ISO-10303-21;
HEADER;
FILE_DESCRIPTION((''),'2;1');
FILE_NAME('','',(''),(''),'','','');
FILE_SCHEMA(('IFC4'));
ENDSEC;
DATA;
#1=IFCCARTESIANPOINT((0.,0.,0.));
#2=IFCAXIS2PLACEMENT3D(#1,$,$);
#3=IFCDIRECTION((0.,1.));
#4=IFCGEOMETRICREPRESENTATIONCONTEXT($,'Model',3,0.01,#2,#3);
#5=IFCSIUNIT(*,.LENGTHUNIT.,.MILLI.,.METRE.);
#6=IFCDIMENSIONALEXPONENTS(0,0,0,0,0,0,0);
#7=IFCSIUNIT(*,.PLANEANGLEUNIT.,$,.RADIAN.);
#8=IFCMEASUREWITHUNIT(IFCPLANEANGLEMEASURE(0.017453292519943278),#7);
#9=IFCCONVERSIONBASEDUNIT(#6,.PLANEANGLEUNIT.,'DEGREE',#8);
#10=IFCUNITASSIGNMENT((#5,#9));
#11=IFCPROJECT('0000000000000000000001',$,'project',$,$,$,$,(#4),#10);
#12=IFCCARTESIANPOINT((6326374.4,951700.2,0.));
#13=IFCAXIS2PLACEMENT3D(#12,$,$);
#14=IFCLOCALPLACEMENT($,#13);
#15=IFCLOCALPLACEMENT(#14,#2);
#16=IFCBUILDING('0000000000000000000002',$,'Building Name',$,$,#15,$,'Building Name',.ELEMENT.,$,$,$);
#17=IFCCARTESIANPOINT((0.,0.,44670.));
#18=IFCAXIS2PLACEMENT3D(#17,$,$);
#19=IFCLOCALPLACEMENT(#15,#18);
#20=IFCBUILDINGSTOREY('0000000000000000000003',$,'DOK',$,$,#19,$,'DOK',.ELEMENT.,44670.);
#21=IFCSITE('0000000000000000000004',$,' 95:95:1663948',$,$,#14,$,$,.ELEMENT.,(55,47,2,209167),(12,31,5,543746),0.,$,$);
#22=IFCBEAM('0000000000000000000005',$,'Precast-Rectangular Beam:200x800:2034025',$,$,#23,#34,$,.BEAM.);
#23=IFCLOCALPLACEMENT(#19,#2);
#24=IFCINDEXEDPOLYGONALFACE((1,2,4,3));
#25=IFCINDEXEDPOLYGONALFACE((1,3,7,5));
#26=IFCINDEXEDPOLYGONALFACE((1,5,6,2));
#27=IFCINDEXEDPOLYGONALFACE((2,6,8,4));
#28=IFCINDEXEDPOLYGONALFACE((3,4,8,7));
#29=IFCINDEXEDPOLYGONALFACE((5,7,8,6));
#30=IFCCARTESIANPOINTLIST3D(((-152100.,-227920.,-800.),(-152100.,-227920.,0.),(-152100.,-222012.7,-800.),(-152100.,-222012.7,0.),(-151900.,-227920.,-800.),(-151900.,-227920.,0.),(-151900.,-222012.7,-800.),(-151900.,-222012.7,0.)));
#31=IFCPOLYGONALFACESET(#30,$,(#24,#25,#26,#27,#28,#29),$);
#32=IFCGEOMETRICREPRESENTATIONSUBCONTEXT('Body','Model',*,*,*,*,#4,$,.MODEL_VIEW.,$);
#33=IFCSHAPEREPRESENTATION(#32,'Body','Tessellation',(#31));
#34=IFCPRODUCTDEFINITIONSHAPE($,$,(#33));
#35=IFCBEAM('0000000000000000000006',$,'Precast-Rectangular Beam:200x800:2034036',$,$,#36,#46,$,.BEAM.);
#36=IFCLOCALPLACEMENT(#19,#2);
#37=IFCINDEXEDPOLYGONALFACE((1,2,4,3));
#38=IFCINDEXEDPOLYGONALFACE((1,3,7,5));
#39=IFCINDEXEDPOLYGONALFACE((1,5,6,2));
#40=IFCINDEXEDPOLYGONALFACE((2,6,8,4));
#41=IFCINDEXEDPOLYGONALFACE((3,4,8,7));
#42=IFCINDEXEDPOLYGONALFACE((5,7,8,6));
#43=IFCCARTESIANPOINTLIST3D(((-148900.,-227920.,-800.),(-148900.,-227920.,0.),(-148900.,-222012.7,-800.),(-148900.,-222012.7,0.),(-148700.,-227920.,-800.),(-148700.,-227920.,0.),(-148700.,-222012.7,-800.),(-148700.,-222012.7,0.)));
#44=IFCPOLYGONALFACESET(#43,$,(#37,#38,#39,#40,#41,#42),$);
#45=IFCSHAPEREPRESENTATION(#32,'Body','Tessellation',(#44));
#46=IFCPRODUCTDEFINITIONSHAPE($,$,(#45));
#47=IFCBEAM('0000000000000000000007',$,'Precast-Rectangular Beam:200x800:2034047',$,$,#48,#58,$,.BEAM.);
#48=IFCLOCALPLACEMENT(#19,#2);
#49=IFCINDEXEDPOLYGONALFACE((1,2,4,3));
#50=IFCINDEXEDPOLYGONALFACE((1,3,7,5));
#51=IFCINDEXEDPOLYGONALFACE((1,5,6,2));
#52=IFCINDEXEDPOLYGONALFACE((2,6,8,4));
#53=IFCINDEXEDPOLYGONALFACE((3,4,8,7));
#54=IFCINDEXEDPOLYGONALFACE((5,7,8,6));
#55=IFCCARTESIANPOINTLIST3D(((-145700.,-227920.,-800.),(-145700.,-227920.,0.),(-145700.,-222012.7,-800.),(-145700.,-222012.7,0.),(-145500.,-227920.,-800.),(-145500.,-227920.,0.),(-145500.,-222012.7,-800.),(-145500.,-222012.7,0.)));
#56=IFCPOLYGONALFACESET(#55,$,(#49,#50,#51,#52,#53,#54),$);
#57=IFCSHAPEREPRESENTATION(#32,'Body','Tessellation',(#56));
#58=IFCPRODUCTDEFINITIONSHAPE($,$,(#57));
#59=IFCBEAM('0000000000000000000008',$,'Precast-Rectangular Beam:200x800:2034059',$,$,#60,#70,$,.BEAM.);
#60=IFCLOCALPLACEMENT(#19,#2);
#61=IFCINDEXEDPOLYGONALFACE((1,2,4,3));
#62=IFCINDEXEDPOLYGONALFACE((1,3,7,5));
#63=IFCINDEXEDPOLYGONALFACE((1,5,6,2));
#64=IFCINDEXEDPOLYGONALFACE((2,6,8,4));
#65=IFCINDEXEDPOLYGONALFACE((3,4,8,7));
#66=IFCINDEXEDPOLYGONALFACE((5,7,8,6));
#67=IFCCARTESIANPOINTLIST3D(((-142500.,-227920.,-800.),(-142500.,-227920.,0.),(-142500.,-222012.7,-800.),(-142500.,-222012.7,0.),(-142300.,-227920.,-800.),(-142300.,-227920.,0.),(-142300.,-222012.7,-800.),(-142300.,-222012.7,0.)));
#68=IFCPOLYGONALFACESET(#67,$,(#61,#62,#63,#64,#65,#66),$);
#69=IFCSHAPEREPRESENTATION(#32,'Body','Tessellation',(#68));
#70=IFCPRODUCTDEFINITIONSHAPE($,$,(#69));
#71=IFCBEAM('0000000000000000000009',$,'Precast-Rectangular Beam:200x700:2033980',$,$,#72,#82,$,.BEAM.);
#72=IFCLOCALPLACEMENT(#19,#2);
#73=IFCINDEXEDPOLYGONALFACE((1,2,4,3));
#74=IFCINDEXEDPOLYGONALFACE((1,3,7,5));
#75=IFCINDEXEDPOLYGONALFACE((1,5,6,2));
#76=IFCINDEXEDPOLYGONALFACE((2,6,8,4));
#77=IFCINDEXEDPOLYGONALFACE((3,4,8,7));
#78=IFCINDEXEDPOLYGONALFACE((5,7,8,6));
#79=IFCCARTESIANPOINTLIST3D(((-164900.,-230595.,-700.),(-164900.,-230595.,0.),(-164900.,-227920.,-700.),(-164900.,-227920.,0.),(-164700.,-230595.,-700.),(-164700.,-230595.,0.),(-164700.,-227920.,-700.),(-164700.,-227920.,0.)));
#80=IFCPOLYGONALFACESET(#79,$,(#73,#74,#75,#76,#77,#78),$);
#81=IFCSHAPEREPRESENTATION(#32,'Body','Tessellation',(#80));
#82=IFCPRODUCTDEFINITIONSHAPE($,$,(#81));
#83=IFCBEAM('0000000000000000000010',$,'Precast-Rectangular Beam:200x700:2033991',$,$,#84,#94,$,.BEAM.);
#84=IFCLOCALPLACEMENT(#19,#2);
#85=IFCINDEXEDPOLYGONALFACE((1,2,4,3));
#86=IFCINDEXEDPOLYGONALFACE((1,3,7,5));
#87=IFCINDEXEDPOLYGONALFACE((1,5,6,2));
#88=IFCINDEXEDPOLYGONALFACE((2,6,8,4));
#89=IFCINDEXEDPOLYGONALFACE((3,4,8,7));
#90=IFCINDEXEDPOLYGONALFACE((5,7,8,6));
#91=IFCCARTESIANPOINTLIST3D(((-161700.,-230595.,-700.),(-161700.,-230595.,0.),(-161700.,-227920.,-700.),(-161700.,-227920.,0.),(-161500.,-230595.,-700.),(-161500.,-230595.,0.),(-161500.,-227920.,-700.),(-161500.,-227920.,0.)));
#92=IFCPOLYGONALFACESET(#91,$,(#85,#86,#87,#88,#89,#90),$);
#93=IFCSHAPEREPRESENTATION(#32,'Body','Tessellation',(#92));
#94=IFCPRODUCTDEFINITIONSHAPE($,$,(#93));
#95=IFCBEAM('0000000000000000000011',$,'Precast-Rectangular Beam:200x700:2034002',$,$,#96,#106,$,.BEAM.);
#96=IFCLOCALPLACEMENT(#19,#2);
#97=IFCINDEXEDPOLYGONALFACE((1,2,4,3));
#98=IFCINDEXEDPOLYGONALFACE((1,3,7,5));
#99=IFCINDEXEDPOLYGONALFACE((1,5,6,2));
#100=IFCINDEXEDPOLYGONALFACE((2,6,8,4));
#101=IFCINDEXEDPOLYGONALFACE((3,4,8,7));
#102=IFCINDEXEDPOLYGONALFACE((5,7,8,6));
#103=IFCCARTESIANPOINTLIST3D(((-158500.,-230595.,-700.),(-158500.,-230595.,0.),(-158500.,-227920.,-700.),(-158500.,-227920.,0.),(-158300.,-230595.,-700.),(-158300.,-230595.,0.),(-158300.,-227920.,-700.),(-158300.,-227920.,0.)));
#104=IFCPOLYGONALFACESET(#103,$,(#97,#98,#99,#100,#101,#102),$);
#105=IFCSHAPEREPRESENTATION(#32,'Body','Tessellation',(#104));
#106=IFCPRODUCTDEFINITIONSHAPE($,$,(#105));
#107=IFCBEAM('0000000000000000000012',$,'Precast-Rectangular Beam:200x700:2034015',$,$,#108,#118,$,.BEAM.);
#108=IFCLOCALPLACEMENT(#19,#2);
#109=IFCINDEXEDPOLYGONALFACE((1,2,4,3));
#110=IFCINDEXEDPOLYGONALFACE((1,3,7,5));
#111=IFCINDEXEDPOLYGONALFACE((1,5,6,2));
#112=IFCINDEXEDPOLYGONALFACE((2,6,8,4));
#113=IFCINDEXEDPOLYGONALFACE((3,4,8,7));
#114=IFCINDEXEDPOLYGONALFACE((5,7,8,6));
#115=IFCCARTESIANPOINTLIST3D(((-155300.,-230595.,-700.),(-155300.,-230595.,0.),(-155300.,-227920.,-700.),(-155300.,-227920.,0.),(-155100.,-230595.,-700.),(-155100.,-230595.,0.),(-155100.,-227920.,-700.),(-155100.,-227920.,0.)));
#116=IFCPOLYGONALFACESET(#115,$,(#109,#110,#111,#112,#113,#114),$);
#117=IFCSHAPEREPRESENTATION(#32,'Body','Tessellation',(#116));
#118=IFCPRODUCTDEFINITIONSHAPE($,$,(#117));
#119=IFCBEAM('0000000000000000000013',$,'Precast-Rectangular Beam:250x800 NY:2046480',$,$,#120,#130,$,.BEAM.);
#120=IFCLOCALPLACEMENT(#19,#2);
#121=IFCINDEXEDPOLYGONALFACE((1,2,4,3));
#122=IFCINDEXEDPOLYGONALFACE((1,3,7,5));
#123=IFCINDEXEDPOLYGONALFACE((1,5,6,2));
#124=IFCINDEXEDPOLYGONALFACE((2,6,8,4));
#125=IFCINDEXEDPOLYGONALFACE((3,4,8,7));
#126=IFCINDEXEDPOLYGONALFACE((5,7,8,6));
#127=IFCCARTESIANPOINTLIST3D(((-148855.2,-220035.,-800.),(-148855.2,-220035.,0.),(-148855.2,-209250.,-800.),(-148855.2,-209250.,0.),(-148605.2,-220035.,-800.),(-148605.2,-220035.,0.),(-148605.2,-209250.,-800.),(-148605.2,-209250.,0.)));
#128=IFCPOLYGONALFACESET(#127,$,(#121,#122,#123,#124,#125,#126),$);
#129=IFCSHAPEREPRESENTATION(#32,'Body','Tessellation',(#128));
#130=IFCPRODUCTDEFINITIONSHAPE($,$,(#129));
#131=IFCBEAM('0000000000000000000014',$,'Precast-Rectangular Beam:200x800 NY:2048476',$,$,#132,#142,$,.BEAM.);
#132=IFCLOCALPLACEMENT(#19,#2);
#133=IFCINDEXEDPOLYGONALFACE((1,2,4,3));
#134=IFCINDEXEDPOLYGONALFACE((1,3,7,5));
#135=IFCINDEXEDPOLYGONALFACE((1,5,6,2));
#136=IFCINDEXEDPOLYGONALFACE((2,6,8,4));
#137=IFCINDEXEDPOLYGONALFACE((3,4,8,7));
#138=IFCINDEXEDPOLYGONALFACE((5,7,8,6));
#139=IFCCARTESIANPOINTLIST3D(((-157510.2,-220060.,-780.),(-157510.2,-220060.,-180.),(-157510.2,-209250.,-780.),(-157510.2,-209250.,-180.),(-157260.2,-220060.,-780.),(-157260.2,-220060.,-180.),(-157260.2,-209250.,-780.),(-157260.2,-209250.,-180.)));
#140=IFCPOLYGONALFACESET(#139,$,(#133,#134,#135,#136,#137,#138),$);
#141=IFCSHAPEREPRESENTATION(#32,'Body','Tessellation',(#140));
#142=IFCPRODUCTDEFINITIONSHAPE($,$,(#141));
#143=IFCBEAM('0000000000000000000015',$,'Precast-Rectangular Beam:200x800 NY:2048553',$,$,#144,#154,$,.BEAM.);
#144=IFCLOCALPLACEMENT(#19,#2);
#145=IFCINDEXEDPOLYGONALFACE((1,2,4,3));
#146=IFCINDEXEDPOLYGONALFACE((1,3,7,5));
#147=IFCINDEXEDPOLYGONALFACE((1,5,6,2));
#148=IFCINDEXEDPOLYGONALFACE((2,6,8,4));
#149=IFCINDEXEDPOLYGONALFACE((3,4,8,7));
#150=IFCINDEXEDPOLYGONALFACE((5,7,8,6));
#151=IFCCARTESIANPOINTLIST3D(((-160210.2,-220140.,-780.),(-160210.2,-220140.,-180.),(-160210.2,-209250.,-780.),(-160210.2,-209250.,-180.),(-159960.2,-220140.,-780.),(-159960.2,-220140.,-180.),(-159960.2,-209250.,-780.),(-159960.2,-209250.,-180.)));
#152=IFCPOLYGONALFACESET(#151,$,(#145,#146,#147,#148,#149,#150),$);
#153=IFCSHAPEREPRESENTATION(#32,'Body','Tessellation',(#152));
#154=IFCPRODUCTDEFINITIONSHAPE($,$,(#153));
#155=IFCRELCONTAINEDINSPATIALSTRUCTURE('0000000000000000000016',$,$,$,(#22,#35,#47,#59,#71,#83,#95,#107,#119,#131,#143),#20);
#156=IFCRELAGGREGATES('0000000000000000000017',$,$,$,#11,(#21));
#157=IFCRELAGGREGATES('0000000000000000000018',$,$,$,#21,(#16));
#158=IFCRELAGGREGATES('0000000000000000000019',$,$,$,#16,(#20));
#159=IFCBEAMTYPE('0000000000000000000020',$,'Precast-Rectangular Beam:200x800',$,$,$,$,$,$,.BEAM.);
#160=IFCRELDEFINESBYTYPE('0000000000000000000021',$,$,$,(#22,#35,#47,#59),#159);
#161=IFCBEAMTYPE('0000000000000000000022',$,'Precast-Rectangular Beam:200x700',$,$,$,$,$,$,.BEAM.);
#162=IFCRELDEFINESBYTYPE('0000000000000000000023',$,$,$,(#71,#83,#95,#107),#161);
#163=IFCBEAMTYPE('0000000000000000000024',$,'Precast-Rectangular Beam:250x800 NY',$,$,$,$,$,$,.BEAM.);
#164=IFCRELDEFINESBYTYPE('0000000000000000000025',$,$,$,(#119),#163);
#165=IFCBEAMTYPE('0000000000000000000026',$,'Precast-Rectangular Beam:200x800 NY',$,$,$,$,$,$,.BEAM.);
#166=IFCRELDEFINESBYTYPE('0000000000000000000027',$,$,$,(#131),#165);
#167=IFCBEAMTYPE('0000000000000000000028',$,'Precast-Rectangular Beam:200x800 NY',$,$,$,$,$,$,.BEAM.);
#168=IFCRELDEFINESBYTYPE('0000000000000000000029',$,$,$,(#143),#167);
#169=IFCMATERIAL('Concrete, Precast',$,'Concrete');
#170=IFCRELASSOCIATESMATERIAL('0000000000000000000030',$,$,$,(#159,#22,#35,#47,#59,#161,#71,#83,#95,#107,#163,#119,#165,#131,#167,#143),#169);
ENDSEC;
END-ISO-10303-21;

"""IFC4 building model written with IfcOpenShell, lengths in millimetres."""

from ifc_helpers import new_model, entity, si_unit, converted_unit, direction, frame, origin, place, context, subcontext, project, spatial, indexed_curve, outline, extrude, source, transform, mapped, material, type_object, type_shapes, element, save


model = new_model("IFC4")

# Units and contexts
model_context = context("Model", 3, precision=0.01, world=origin(), true_north=direction((0.0, 1.0)))
body_context = subcontext(model_context, "Body", "Model", "MODEL_VIEW")
ifc_project = project(units=[si_unit("LENGTHUNIT", "METRE", prefix="MILLI"), converted_unit("PLANEANGLEUNIT", "DEGREE", entity("IfcPlaneAngleMeasure", 0.017453292519943278), si_unit("PLANEANGLEUNIT", "RADIAN"), dimensions=[0, 0, 0, 0, 0, 0, 0])], contexts=[model_context])

# Site, building, storey
site_placement = place(None, frame((6326374.4, 951700.2, 0.0)))
site = spatial("IfcSite", under=ifc_project, at=site_placement, Name=" 95:95:1663948", CompositionType="ELEMENT", RefLatitude=(55, 47, 2, 209167), RefLongitude=(12, 31, 5, 543746), RefElevation=0.0)
building_placement = place(site_placement, origin())
building = spatial("IfcBuilding", under=site, at=building_placement, Name="Building Name", LongName="Building Name", CompositionType="ELEMENT")
storey_placement = place(building_placement, frame((0.0, 0.0, 44670.0)))
storey = spatial("IfcBuildingStorey", under=building, at=storey_placement, Name="DOK", LongName="DOK", CompositionType="ELEMENT", Elevation=44670.0)

# Beams
ifc_material_1 = material(Name="Concrete, Precast", Category="Concrete")
beam_type_1 = type_object("IfcBeamType", Name="Precast-Rectangular Beam:200x800", PredefinedType="BEAM", material=ifc_material_1)
shared_shape_1 = source(origin(), body_context, "Body", "SweptSolid", [
    extrude(outline(indexed_curve([(-2953.7, -100.0), (2953.7, -100.0), (2953.7, 100.0), (-2953.7, 100.0), (-2953.7, -100.0)], self_intersect=False)), frame((-66.4, 0.0, -400.0), z_axis=(0.0, 0.0, 1.0), x_axis=(-1.0, 0.0, 0.0)), (0.0, 0.0, 1.0), 800.0),
])
type_shapes(beam_type_1, [shared_shape_1])
for number, where, z_axis, x_axis, name in (
    (1, (-152000.0, -224900.0, -400.0), (0.0, 0.0, 1.0), (0.0, 1.0, 0.0), "Precast-Rectangular Beam:200x800:2034025"),
    (2, (-148800.0, -224900.0, -400.0), (0.0, 0.0, 1.0), (0.0, 1.0, 0.0), "Precast-Rectangular Beam:200x800:2034036"),
    (3, (-145600.0, -224900.0, -400.0), (0.0, 0.0, 1.0), (0.0, 1.0, 0.0), "Precast-Rectangular Beam:200x800:2034047"),
    (4, (-142400.0, -224900.0, -400.0), (0.0, 0.0, 1.0), (0.0, 1.0, 0.0), "Precast-Rectangular Beam:200x800:2034059"),
):
    element("IfcBeam", number, at=place(storey_placement, frame(where, z_axis=z_axis, x_axis=x_axis)), inside=storey, type_object=beam_type_1, material=ifc_material_1, Name=name, PredefinedType="BEAM", context=body_context, shape_type="MappedRepresentation", body=[
        mapped(shared_shape_1, transform((0.0, 0.0, 0.0), scale=1.0)),
    ])
beam_type_2 = type_object("IfcBeamType", Name="Precast-Rectangular Beam:200x700", PredefinedType="BEAM", material=ifc_material_1)
shared_shape_2 = source(origin(), body_context, "Body", "SweptSolid", [
    extrude(outline(indexed_curve([(-1337.5, -100.0), (1337.5, -100.0), (1337.5, 100.0), (-1337.5, 100.0), (-1337.5, -100.0)], self_intersect=False)), frame((0.0, 0.0, -350.0), z_axis=(0.0, 0.0, 1.0), x_axis=(-1.0, 0.0, 0.0)), (0.0, 0.0, 1.0), 700.0),
])
type_shapes(beam_type_2, [shared_shape_2])
for number, where, z_axis, x_axis, name in (
    (5, (-164800.0, -229257.5, -350.0), (0.0, 0.0, 1.0), (0.0, -1.0, 0.0), "Precast-Rectangular Beam:200x700:2033980"),
    (6, (-161600.0, -229257.5, -350.0), (0.0, 0.0, 1.0), (0.0, -1.0, 0.0), "Precast-Rectangular Beam:200x700:2033991"),
    (7, (-158400.0, -229257.5, -350.0), (0.0, 0.0, 1.0), (0.0, -1.0, 0.0), "Precast-Rectangular Beam:200x700:2034002"),
    (8, (-155200.0, -229257.5, -350.0), (0.0, 0.0, 1.0), (0.0, -1.0, 0.0), "Precast-Rectangular Beam:200x700:2034015"),
):
    element("IfcBeam", number, at=place(storey_placement, frame(where, z_axis=z_axis, x_axis=x_axis)), inside=storey, type_object=beam_type_2, material=ifc_material_1, Name=name, PredefinedType="BEAM", context=body_context, shape_type="MappedRepresentation", body=[
        mapped(shared_shape_2, transform((0.0, 0.0, 0.0), scale=1.0)),
    ])
beam_type_3 = type_object("IfcBeamType", Name="Precast-Rectangular Beam:250x800 NY", PredefinedType="BEAM", material=ifc_material_1)
shared_shape_3 = source(origin(), body_context, "Body", "SweptSolid", [
    extrude(outline(indexed_curve([(-5392.5, -125.0), (5392.5, -125.0), (5392.5, 125.0), (-5392.5, 125.0), (-5392.5, -125.0)], self_intersect=False)), frame((-62.5, 0.0, -400.0), z_axis=(0.0, 0.0, 1.0), x_axis=(-1.0, 0.0, 0.0)), (0.0, 0.0, 1.0), 800.0),
])
type_shapes(beam_type_3, [shared_shape_3])
beam_1_placement = place(storey_placement, frame((-148730.2, -214705.0, -400.0), z_axis=(0.0, 0.0, 1.0), x_axis=(0.0, -1.0, 0.0)))
element("IfcBeam", 9, at=beam_1_placement, inside=storey, type_object=beam_type_3, material=ifc_material_1, Name="Precast-Rectangular Beam:250x800 NY:2046480", PredefinedType="BEAM", context=body_context, shape_type="MappedRepresentation", body=[
    mapped(shared_shape_3, transform((0.0, 0.0, 0.0), scale=1.0)),
])
beam_type_4 = type_object("IfcBeamType", Name="Precast-Rectangular Beam:200x800 NY", PredefinedType="BEAM", material=ifc_material_1)
shared_shape_4 = source(origin(), body_context, "Body", "SweptSolid", [
    extrude(outline(indexed_curve([(-5405.0, -125.0), (5405.0, -125.0), (5405.0, 125.0), (-5405.0, 125.0), (-5405.0, -125.0)], self_intersect=False)), frame((-50.0, 0.0, -300.0), z_axis=(0.0, 0.0, 1.0), x_axis=(-1.0, 0.0, 0.0)), (0.0, 0.0, 1.0), 600.0),
])
type_shapes(beam_type_4, [shared_shape_4])
beam_2_placement = place(storey_placement, frame((-157385.2, -214705.0, -480.0), z_axis=(0.0, 0.0, 1.0), x_axis=(0.0, -1.0, 0.0)))
element("IfcBeam", 10, at=beam_2_placement, inside=storey, type_object=beam_type_4, material=ifc_material_1, Name="Precast-Rectangular Beam:200x800 NY:2048476", PredefinedType="BEAM", context=body_context, shape_type="MappedRepresentation", body=[
    mapped(shared_shape_4, transform((0.0, 0.0, 0.0), scale=1.0)),
])
beam_type_5 = type_object("IfcBeamType", Name="Precast-Rectangular Beam:200x800 NY", PredefinedType="BEAM", material=ifc_material_1)
shared_shape_5 = source(origin(), body_context, "Body", "SweptSolid", [
    extrude(outline(indexed_curve([(-5445.0, -125.0), (5445.0, -125.0), (5445.0, 125.0), (-5445.0, 125.0), (-5445.0, -125.0)], self_intersect=False)), frame((30.0, 0.0, -300.0), z_axis=(0.0, 0.0, 1.0), x_axis=(-1.0, 0.0, 0.0)), (0.0, 0.0, 1.0), 600.0),
])
type_shapes(beam_type_5, [shared_shape_5])
beam_3_placement = place(storey_placement, frame((-160085.2, -214725.0, -480.0), z_axis=(0.0, 0.0, 1.0), x_axis=(0.0, 1.0, 0.0)))
element("IfcBeam", 11, at=beam_3_placement, inside=storey, type_object=beam_type_5, material=ifc_material_1, Name="Precast-Rectangular Beam:200x800 NY:2048553", PredefinedType="BEAM", context=body_context, shape_type="MappedRepresentation", body=[
    mapped(shared_shape_5, transform((0.0, 0.0, 0.0), scale=1.0)),
])

save(model, "model.ifc")
